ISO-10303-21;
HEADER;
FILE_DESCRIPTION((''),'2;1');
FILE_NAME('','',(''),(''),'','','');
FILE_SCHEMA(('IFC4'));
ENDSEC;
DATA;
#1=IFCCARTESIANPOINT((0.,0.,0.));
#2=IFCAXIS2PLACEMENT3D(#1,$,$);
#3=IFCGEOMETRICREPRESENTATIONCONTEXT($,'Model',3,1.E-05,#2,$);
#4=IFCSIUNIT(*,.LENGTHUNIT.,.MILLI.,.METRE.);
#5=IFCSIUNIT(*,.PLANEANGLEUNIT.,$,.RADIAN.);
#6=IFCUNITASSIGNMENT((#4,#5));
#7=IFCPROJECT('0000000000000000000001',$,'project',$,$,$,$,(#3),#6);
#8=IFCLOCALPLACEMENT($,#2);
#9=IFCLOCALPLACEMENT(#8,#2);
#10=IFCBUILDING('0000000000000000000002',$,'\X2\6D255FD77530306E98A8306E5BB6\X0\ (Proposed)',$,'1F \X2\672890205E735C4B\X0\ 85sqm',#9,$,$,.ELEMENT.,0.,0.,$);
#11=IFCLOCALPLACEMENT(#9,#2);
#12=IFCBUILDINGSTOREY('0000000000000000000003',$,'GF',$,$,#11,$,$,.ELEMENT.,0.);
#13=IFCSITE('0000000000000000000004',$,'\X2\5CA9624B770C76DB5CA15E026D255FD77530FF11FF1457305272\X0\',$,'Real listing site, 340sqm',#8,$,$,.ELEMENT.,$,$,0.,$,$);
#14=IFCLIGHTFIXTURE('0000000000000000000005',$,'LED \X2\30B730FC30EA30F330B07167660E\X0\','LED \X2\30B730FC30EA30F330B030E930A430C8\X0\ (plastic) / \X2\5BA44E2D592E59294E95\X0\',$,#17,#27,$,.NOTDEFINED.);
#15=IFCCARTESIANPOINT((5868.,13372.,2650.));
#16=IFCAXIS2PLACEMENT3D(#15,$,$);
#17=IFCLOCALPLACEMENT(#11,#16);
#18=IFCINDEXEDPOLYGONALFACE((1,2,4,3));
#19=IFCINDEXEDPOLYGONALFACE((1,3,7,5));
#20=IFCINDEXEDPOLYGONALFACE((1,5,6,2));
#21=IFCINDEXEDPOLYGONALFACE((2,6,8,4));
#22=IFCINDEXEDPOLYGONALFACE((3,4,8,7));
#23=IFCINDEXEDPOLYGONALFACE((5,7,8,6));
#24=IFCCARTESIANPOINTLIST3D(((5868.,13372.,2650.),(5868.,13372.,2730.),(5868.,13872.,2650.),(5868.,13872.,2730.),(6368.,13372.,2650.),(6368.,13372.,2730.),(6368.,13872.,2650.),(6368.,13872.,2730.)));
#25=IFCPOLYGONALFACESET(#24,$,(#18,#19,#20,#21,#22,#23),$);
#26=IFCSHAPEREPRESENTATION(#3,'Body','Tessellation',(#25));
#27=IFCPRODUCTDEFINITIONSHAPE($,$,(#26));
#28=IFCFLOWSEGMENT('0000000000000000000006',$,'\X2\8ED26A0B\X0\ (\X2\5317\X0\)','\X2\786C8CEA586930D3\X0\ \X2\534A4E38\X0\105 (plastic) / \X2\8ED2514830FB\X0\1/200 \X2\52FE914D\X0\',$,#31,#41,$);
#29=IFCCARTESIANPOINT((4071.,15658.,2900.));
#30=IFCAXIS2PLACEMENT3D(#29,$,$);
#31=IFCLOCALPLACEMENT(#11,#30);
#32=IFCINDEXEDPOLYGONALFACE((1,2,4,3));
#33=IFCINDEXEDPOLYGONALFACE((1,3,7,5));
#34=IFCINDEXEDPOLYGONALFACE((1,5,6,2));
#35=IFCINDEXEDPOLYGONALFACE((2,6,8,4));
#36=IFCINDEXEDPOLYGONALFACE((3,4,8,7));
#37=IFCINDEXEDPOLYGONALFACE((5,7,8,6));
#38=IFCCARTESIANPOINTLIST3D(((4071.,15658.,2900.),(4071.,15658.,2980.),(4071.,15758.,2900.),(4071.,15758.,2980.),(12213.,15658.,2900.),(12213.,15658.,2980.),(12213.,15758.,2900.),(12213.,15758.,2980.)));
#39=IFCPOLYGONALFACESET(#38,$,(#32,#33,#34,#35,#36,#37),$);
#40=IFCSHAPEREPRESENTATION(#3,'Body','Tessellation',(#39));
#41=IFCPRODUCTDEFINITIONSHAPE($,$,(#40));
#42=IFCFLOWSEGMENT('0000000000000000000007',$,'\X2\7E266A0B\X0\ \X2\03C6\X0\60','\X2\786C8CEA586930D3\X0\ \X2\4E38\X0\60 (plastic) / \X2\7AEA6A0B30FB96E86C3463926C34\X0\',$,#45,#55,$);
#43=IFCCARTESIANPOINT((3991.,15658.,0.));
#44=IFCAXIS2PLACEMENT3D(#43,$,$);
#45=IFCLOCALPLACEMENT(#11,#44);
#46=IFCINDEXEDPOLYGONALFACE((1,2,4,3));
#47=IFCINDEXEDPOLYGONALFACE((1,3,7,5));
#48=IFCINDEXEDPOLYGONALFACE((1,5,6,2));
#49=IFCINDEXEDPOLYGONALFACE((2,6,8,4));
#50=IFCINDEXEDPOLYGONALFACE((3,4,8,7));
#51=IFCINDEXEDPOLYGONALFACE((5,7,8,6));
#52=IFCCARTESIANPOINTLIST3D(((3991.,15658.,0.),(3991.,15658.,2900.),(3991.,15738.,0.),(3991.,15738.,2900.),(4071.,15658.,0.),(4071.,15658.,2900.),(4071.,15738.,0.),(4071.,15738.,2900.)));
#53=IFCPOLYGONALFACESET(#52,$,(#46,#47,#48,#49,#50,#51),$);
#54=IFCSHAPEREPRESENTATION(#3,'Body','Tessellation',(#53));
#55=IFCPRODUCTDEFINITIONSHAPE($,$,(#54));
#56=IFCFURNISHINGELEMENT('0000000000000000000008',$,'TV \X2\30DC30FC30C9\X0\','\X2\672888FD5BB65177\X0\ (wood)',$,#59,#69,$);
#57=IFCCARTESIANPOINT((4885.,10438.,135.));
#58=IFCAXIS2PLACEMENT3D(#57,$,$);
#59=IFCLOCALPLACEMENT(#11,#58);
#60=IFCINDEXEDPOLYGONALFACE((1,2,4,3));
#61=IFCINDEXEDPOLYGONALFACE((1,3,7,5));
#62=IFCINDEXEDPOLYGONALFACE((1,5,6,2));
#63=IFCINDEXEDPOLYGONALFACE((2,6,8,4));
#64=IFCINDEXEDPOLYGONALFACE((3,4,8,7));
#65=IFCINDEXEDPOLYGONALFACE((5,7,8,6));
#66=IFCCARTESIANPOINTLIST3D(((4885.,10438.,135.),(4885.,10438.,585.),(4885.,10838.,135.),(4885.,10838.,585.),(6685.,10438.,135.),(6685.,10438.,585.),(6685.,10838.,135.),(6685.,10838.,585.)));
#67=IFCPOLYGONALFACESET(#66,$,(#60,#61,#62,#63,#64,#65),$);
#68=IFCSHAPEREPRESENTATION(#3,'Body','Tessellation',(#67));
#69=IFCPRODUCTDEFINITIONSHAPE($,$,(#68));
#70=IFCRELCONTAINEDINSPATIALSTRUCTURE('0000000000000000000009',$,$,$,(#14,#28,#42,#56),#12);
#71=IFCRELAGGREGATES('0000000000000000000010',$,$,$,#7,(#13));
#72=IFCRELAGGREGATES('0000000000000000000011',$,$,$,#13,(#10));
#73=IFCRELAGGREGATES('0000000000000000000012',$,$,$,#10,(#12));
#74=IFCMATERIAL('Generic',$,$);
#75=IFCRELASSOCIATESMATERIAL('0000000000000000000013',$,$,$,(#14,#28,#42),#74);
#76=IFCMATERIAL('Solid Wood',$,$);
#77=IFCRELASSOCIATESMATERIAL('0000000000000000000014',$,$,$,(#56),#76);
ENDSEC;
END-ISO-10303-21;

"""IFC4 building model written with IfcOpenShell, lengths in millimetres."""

from ifc_helpers import new_model, si_unit, frame, frame_2d, origin, place, context, project, spatial, rectangle, extrude, material, element, save


model = new_model("IFC4")

# Units and contexts
model_context = context("Model", 3, precision=1e-05, world=origin())
ifc_project = project(units=[si_unit("LENGTHUNIT", "METRE", prefix="MILLI"), si_unit("PLANEANGLEUNIT", "RADIAN")], contexts=[model_context])

# Site, building, storey
site_placement = place(None, origin())
site = spatial("IfcSite", under=ifc_project, at=site_placement, Name="岩手県盛岡市津志田１４地割", ObjectType="Real listing site, 340sqm", CompositionType="ELEMENT", RefElevation=0.0)
building_placement = place(site_placement, origin())
building = spatial("IfcBuilding", under=site, at=building_placement, Name="津志田の風の家 (Proposed)", ObjectType="1F 木造平屋 85sqm", CompositionType="ELEMENT", ElevationOfRefHeight=0.0, ElevationOfTerrain=0.0)
storey_placement = place(building_placement, origin())
storey = spatial("IfcBuildingStorey", under=building, at=storey_placement, Name="GF", CompositionType="ELEMENT", Elevation=0.0)

# Shared definitions
ifc_material_1 = material(Name="Solid Wood")

# Shared definitions
ifc_material_2 = material(Name="Generic")

# Light fixture
light_fixture_placement = place(storey_placement, frame((5868.0, 13372.0, 2650.0)))
element("IfcLightFixture", 1, at=light_fixture_placement, inside=storey, material=ifc_material_2, Name="LED シーリング照明", Description="LED シーリングライト (plastic) / 室中央天井", PredefinedType="NOTDEFINED", context=model_context, shape_type="SweptSolid", body=[
    extrude(rectangle(XDim=500.0, YDim=500.0, at=frame_2d((250.0, 250.0))), frame((5868.0, 13372.0, 2650.0)), (0.0, 0.0, 1.0), 80.0),
])

# Flow segments
flow_segment_1_placement = place(storey_placement, frame((4071.0, 15658.0, 2900.0)))
element("IfcFlowSegment", 2, at=flow_segment_1_placement, inside=storey, material=ifc_material_2, Name="軒樋 (北)", Description="硬質塩ビ 半丸105 (plastic) / 軒先・1/200 勾配", context=model_context, shape_type="SweptSolid", body=[
    extrude(rectangle(XDim=8142.0, YDim=100.0, at=frame_2d((4071.0, 50.0))), frame((4071.0, 15658.0, 2900.0)), (0.0, 0.0, 1.0), 80.0),
])
flow_segment_2_placement = place(storey_placement, frame((3991.0, 15658.0, 0.0)))
element("IfcFlowSegment", 3, at=flow_segment_2_placement, inside=storey, material=ifc_material_2, Name="縦樋 φ60", Description="硬質塩ビ 丸60 (plastic) / 竪樋・雨水排水", context=model_context, shape_type="SweptSolid", body=[
    extrude(rectangle(XDim=80.0, YDim=80.0, at=frame_2d((40.0, 40.0))), frame((3991.0, 15658.0, 0.0)), (0.0, 0.0, 1.0), 2900.0),
])

# Furnishing element
furnishing_placement = place(storey_placement, frame((4885.0, 10438.0, 135.0)))
element("IfcFurnishingElement", 4, at=furnishing_placement, inside=storey, material=ifc_material_1, Name="TV ボード", Description="木製家具 (wood)", context=model_context, shape_type="SweptSolid", body=[
    extrude(rectangle(XDim=1800.0, YDim=400.0, at=frame_2d((900.0, 200.0))), frame((4885.0, 10438.0, 135.0)), (0.0, 0.0, 1.0), 450.0),
])

save(model, "model.ifc")
